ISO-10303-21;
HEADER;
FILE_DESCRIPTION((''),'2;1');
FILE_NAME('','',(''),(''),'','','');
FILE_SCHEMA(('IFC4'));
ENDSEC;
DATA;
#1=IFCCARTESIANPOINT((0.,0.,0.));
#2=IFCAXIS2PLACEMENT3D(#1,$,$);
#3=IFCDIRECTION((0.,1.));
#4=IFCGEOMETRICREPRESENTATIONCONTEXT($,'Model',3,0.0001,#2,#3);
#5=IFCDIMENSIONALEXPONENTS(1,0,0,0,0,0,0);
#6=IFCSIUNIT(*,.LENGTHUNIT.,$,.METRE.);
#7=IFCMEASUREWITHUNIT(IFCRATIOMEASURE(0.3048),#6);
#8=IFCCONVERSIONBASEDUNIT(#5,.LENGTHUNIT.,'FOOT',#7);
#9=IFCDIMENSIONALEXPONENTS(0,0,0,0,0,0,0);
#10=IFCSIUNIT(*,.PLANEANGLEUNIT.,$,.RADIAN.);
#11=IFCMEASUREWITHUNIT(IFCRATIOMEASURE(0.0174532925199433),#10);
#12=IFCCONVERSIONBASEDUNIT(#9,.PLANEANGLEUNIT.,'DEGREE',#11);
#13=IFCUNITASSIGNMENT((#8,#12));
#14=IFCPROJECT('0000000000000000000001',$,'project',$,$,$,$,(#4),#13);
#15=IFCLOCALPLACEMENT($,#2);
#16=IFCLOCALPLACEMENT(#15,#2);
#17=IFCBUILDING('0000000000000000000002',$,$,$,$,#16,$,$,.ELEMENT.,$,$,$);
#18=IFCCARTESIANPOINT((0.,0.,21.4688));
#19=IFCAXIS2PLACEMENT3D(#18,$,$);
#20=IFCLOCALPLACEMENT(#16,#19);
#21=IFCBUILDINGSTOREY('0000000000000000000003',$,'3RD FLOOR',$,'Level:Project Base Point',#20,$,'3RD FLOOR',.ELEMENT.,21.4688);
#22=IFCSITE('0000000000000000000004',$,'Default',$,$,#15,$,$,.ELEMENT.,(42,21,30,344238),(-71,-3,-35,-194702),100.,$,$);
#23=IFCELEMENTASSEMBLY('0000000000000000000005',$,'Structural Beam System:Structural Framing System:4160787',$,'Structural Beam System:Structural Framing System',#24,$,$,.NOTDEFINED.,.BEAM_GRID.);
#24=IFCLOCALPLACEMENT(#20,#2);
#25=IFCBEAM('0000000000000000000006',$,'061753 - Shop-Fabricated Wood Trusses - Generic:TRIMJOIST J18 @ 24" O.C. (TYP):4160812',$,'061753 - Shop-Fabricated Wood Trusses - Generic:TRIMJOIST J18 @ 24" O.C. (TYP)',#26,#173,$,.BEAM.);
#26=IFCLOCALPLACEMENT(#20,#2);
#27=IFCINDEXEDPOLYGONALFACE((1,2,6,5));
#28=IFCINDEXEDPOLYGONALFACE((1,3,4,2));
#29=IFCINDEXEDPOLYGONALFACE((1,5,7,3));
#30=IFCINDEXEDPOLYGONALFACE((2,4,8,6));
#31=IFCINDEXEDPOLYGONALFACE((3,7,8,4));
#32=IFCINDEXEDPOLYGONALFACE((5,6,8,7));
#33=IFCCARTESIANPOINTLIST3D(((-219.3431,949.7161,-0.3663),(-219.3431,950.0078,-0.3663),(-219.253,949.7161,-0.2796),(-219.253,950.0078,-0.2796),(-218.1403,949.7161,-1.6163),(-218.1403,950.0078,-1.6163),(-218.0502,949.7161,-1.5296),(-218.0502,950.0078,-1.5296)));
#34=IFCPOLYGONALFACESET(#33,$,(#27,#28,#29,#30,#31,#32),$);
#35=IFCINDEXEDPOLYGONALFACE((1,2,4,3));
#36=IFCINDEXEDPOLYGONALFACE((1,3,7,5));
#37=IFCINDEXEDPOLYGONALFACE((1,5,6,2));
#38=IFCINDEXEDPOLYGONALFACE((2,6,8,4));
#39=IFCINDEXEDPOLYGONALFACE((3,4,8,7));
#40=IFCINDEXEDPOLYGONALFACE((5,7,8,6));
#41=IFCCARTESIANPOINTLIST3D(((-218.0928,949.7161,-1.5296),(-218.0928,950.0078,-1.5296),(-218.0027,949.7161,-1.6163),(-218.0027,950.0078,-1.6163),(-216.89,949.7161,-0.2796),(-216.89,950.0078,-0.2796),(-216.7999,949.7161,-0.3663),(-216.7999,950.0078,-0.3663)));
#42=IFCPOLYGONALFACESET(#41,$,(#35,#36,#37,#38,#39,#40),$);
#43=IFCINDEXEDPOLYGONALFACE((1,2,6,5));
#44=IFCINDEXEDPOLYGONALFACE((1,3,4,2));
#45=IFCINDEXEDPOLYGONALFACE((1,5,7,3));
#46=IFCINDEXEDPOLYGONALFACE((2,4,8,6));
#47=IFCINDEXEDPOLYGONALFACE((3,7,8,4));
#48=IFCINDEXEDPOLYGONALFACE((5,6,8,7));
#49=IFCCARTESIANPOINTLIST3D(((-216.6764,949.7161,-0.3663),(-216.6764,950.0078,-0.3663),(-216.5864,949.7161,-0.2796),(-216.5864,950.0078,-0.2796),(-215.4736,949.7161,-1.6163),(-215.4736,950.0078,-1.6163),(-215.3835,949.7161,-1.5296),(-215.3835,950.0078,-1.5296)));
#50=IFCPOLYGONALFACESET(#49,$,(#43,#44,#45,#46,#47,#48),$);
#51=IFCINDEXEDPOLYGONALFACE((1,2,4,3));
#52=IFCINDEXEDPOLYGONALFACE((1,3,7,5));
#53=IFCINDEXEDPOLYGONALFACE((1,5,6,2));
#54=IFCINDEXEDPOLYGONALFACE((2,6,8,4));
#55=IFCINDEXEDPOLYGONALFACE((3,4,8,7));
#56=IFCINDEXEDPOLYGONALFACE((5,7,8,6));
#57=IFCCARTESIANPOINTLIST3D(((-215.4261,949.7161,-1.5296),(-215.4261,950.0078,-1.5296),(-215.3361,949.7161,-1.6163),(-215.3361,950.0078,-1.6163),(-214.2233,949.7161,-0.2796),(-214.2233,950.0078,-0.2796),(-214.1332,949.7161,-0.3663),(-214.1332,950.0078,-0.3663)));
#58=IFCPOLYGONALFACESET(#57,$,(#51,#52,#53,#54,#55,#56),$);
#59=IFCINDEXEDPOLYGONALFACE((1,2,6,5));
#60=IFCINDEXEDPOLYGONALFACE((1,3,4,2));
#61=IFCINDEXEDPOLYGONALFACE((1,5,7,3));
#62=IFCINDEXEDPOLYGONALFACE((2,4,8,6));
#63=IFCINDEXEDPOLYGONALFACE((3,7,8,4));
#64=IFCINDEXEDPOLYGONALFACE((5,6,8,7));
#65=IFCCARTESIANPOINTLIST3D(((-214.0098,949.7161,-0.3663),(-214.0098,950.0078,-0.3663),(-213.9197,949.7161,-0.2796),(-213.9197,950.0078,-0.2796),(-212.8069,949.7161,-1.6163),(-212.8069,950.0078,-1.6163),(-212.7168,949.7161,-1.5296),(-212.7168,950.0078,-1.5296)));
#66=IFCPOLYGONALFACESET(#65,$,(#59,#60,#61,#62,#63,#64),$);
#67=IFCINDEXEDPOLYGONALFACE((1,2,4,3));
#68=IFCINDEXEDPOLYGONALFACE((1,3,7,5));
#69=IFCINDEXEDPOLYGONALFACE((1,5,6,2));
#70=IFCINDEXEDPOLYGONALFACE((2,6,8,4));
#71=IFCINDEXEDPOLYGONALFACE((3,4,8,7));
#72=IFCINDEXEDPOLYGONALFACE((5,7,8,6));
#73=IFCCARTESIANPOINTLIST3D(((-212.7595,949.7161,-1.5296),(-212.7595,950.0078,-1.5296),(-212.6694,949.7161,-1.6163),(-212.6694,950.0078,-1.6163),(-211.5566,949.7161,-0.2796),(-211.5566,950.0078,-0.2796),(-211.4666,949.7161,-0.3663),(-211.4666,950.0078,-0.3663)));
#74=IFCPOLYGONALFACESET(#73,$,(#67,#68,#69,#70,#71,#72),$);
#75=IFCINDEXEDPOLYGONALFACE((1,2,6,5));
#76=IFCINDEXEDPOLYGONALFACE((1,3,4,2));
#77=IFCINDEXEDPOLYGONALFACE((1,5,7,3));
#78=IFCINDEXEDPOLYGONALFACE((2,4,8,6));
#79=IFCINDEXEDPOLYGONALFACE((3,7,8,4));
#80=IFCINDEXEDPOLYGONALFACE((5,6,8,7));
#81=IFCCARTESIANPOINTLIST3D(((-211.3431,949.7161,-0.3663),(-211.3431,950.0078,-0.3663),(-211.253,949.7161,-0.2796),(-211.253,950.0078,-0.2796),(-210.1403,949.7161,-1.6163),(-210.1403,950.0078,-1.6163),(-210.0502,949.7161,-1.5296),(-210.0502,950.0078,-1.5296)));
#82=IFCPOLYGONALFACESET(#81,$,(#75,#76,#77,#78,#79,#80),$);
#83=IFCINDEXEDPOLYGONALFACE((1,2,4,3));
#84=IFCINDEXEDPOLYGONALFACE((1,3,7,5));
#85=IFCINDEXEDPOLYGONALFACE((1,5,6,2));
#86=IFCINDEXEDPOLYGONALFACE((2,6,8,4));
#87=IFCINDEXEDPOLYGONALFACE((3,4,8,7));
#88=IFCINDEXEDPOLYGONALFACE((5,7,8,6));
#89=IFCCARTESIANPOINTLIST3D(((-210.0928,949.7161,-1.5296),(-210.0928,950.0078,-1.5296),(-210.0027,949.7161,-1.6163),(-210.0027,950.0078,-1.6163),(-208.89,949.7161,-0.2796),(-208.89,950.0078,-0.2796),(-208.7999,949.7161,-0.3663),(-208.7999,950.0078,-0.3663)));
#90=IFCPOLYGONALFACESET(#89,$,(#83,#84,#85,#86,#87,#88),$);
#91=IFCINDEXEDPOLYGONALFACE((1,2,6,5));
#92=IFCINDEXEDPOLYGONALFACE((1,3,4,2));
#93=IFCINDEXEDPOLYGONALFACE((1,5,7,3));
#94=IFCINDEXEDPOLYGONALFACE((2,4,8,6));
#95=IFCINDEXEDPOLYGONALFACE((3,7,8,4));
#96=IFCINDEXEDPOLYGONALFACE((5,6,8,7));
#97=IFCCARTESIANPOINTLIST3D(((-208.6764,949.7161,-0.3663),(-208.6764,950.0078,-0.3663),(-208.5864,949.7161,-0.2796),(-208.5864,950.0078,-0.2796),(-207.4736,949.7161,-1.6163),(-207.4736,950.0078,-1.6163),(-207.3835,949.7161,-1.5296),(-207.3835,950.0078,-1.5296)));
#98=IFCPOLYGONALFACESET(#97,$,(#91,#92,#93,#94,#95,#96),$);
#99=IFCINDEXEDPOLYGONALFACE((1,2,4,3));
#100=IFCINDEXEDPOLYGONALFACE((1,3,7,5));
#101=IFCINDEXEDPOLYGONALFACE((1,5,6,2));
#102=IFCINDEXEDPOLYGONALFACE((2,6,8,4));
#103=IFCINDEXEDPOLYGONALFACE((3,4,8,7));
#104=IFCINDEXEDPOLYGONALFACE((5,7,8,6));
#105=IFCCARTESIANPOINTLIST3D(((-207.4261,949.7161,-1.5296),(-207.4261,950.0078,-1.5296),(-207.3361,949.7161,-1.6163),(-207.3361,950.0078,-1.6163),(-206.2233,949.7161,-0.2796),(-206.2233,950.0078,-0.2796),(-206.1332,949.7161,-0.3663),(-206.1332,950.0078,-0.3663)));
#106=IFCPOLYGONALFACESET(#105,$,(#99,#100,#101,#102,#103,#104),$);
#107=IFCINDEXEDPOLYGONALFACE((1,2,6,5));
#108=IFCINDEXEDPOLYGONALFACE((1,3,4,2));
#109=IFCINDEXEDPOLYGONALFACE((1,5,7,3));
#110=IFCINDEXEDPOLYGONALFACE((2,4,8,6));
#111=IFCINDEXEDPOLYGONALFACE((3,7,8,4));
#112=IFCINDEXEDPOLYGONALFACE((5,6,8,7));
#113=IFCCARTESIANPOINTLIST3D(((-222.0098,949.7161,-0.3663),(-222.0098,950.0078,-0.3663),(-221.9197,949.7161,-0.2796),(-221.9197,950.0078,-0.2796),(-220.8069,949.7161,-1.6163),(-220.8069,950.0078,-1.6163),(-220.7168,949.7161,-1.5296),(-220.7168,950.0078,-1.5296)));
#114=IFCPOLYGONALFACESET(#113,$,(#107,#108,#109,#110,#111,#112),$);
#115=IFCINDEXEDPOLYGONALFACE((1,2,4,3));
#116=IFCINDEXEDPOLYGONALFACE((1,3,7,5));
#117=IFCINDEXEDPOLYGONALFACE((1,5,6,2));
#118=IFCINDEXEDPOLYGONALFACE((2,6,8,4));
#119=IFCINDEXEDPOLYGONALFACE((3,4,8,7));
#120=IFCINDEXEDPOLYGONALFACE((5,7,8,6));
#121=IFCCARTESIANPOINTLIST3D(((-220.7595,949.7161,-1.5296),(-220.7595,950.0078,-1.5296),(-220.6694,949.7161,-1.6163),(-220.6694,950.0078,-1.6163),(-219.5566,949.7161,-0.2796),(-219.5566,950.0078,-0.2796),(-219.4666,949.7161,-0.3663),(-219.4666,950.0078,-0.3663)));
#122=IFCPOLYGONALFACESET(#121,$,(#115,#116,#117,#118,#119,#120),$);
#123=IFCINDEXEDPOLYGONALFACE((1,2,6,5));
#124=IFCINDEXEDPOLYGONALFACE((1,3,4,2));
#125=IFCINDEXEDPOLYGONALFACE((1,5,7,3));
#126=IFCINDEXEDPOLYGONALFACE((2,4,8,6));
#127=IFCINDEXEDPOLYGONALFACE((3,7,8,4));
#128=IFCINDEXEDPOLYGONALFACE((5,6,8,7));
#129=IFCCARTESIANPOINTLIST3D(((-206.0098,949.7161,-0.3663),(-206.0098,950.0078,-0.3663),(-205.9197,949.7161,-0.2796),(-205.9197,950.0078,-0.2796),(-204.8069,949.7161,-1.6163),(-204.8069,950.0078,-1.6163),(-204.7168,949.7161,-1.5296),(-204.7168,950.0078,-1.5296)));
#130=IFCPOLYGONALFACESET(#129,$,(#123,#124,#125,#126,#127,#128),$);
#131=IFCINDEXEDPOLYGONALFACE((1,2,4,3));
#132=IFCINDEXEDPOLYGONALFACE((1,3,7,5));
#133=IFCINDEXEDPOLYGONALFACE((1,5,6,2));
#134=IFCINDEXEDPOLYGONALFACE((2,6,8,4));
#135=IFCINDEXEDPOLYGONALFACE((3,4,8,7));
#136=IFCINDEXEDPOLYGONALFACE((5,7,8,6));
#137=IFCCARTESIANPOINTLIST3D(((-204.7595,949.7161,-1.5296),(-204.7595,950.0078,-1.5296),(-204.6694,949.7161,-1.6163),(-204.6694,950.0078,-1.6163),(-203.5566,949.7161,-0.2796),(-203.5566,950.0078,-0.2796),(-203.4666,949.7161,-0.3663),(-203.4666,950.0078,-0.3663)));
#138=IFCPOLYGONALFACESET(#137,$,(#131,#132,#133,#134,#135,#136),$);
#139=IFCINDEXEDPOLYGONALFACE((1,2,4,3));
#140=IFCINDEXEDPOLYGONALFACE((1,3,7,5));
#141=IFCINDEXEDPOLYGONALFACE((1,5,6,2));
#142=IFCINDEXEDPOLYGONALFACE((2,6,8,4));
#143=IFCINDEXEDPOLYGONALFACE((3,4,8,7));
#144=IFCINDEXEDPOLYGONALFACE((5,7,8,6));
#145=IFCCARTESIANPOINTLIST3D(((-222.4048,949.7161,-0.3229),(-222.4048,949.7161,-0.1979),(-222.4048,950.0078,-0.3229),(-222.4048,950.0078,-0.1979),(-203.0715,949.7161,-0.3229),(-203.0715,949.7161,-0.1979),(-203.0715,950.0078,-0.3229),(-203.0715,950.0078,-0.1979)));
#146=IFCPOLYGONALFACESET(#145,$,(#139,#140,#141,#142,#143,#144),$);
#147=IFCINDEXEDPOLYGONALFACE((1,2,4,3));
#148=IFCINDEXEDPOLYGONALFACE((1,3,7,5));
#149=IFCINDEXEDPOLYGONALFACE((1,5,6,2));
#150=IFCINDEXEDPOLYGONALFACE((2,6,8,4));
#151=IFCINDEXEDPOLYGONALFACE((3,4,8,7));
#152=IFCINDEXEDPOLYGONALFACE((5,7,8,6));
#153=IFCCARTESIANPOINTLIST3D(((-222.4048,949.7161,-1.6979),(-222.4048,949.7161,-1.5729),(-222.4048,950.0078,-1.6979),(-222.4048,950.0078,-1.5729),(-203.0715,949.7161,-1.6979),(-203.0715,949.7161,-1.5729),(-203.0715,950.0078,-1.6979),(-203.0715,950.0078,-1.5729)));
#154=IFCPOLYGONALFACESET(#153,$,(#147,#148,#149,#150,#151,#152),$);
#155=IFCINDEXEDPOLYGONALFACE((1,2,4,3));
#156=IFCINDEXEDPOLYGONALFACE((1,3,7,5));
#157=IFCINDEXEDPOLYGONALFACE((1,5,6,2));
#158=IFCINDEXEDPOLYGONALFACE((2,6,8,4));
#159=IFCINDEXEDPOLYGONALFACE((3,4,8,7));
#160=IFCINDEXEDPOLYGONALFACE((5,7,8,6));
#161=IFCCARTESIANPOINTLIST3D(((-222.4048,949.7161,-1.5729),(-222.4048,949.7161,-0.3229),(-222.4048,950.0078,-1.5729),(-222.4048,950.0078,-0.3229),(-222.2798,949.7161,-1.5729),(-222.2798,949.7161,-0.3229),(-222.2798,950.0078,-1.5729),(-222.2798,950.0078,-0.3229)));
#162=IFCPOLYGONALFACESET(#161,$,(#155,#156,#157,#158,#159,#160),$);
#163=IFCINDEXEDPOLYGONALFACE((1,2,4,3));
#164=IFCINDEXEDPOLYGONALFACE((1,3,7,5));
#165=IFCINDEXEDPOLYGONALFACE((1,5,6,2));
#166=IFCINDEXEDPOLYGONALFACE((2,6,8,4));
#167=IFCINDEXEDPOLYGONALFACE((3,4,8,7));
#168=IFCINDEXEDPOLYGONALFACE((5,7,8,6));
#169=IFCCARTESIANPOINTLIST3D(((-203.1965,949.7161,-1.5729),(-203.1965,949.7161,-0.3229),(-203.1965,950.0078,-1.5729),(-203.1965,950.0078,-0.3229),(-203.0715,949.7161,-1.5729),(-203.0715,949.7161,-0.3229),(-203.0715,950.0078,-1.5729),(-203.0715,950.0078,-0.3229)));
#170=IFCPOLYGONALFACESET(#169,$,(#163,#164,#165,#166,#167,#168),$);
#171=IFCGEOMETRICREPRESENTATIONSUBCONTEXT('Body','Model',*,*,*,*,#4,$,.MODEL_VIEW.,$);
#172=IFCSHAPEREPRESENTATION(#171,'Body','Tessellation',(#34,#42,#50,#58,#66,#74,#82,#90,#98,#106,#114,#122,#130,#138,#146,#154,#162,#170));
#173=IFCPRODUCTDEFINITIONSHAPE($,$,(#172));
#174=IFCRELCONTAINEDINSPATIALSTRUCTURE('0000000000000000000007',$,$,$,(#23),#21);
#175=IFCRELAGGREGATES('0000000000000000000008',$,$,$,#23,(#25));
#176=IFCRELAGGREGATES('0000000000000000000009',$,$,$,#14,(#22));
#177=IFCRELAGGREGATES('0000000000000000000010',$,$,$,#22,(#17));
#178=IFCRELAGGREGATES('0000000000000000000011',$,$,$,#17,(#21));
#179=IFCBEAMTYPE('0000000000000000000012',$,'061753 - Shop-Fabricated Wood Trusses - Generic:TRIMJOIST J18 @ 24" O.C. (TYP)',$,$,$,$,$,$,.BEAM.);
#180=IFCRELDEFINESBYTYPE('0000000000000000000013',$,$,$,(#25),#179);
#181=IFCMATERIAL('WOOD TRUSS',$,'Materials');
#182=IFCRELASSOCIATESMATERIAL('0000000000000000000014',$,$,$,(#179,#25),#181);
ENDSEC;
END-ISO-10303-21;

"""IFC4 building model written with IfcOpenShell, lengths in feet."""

from ifc_helpers import new_model, entity, si_unit, converted_unit, direction, frame, frame_2d, origin, origin_2d_with_axis, place, context, subcontext, project, spatial, rectangle, extrude, source, transform, mapped, material, material_profile, profile_set, profile_usage, type_object, type_shapes, element, aggregate, save


model = new_model("IFC4")

# Units and contexts
model_context = context("Model", 3, precision=0.0001, world=origin(), true_north=direction((0.0, 1.0)))
body_context = subcontext(model_context, "Body", "Model", "MODEL_VIEW")
ifc_project = project(units=[converted_unit("LENGTHUNIT", "FOOT", entity("IfcRatioMeasure", 0.3048), si_unit("LENGTHUNIT", "METRE"), dimensions=[1, 0, 0, 0, 0, 0, 0]), converted_unit("PLANEANGLEUNIT", "DEGREE", entity("IfcRatioMeasure", 0.0174532925199433), si_unit("PLANEANGLEUNIT", "RADIAN"), dimensions=[0, 0, 0, 0, 0, 0, 0])], contexts=[model_context])

# Site, building, storey
site_placement = place(None, origin())
site = spatial("IfcSite", under=ifc_project, at=site_placement, Name="Default", CompositionType="ELEMENT", RefLatitude=(42, 21, 30, 344238), RefLongitude=(-71, -3, -35, -194702), RefElevation=100.0)
building_placement = place(site_placement, origin())
building = spatial("IfcBuilding", under=site, at=building_placement, CompositionType="ELEMENT")
storey_placement = place(building_placement, frame((0.0, 0.0, 21.4688)))
storey = spatial("IfcBuildingStorey", under=building, at=storey_placement, Name="3RD FLOOR", ObjectType="Level:Project Base Point", LongName="3RD FLOOR", CompositionType="ELEMENT", Elevation=21.4688)

# Shared definitions
ifc_material = material(Name="WOOD TRUSS", Category="Materials")
ifc_material_profile_1 = material_profile(ifc_material, rectangle(XDim=1.7347, YDim=0.125, at=frame_2d((0.0, 0.0), x_axis=(1.0, 0.0))), Name="TRIMJOIST J18 @ 24\" O.C. (TYP)")
ifc_material_profile_2 = material_profile(ifc_material, rectangle(XDim=1.7347, YDim=0.125, at=frame_2d((0.0, 0.0), x_axis=(1.0, 0.0))), Name="TRIMJOIST J18 @ 24\" O.C. (TYP)")
ifc_material_profile_3 = material_profile(ifc_material, rectangle(XDim=1.7347, YDim=0.125, at=frame_2d((0.0, 0.0), x_axis=(1.0, 0.0))), Name="TRIMJOIST J18 @ 24\" O.C. (TYP)")
ifc_material_profile_4 = material_profile(ifc_material, rectangle(XDim=1.7347, YDim=0.125, at=frame_2d((0.0, 0.0), x_axis=(1.0, 0.0))), Name="TRIMJOIST J18 @ 24\" O.C. (TYP)")
ifc_material_profile_5 = material_profile(ifc_material, rectangle(XDim=1.7347, YDim=0.125, at=frame_2d((0.0, 0.0), x_axis=(1.0, 0.0))), Name="TRIMJOIST J18 @ 24\" O.C. (TYP)")
ifc_material_profile_6 = material_profile(ifc_material, rectangle(XDim=1.7347, YDim=0.125, at=frame_2d((0.0, 0.0), x_axis=(1.0, 0.0))), Name="TRIMJOIST J18 @ 24\" O.C. (TYP)")
ifc_material_profile_7 = material_profile(ifc_material, rectangle(XDim=1.7347, YDim=0.125, at=frame_2d((0.0, 0.0), x_axis=(1.0, 0.0))), Name="TRIMJOIST J18 @ 24\" O.C. (TYP)")
ifc_material_profile_8 = material_profile(ifc_material, rectangle(XDim=1.7347, YDim=0.125, at=frame_2d((0.0, 0.0), x_axis=(1.0, 0.0))), Name="TRIMJOIST J18 @ 24\" O.C. (TYP)")
ifc_material_profile_9 = material_profile(ifc_material, rectangle(XDim=1.7347, YDim=0.125, at=frame_2d((0.0, 0.0), x_axis=(1.0, 0.0))), Name="TRIMJOIST J18 @ 24\" O.C. (TYP)")
ifc_material_profile_10 = material_profile(ifc_material, rectangle(XDim=1.7347, YDim=0.125, at=origin_2d_with_axis()), Name="TRIMJOIST J18 @ 24\" O.C. (TYP)")
ifc_material_profile_11 = material_profile(ifc_material, rectangle(XDim=0.125, YDim=0.2917, at=origin_2d_with_axis()), Name="TRIMJOIST J18 @ 24\" O.C. (TYP)")
ifc_material_profile_12 = material_profile(ifc_material, rectangle(XDim=0.125, YDim=0.2917, at=origin_2d_with_axis()), Name="TRIMJOIST J18 @ 24\" O.C. (TYP)")
ifc_material_profile_13 = material_profile(ifc_material, rectangle(XDim=1.25, YDim=0.2917, at=origin_2d_with_axis()), Name="TRIMJOIST J18 @ 24\" O.C. (TYP)")
ifc_material_profile_14 = material_profile(ifc_material, rectangle(XDim=1.25, YDim=0.2917, at=origin_2d_with_axis()), Name="TRIMJOIST J18 @ 24\" O.C. (TYP)")
ifc_profile_set = profile_set([ifc_material_profile_1, ifc_material_profile_2, ifc_material_profile_3, ifc_material_profile_4, ifc_material_profile_5, ifc_material_profile_6, ifc_material_profile_7, ifc_material_profile_8, ifc_material_profile_9, ifc_material_profile_10, ifc_material_profile_11, ifc_material_profile_12, ifc_material_profile_13, ifc_material_profile_14], Name="TRIMJOIST J18 @ 24\" O.C. (TYP)")
beam_type_1 = type_object("IfcBeamType", Name="061753 - Shop-Fabricated Wood Trusses - Generic:TRIMJOIST J18 @ 24\" O.C. (TYP)", PredefinedType="BEAM", material=ifc_profile_set)
shared_shape_1 = source(origin(), body_context, "Body", "SweptSolid", [
    extrude(rectangle(XDim=1.7347, YDim=0.125, at=frame_2d((0.0, 0.0), x_axis=(1.0, 0.0))), frame((5.9585, -0.1458, 0.0), z_axis=(0.0, 1.0, 0.0), x_axis=(0.693383, 0.0, 0.720569)), (0.0, 0.0, 1.0), 0.2917),
    extrude(rectangle(XDim=1.7347, YDim=0.125, at=origin_2d_with_axis()), frame((4.7082, -0.1458, 0.0), z_axis=(0.0, 1.0, 0.0), x_axis=(0.693383, 0.0, -0.720569)), (0.0, 0.0, 1.0), 0.2917),
    extrude(rectangle(XDim=1.7347, YDim=0.125, at=frame_2d((0.0, 0.0), x_axis=(1.0, 0.0))), frame((3.2918, -0.1458, 0.0), z_axis=(0.0, 1.0, 0.0), x_axis=(0.693383, 0.0, 0.720569)), (0.0, 0.0, 1.0), 0.2917),
    extrude(rectangle(XDim=1.7347, YDim=0.125, at=frame_2d((0.0, 0.0), x_axis=(1.0, 0.0))), frame((2.0415, -0.1458, 0.0), z_axis=(0.0, 1.0, 0.0), x_axis=(0.693383, 0.0, -0.720569)), (0.0, 0.0, 1.0), 0.2917),
    extrude(rectangle(XDim=1.7347, YDim=0.125, at=frame_2d((0.0, 0.0), x_axis=(1.0, 0.0))), frame((0.6251, -0.1458, 0.0), z_axis=(0.0, 1.0, 0.0), x_axis=(0.693383, 0.0, 0.720569)), (0.0, 0.0, 1.0), 0.2917),
    extrude(rectangle(XDim=1.7347, YDim=0.125, at=frame_2d((0.0, 0.0), x_axis=(1.0, 0.0))), frame((-0.6251, -0.1458, 0.0), z_axis=(0.0, 1.0, 0.0), x_axis=(0.693383, 0.0, -0.720569)), (0.0, 0.0, 1.0), 0.2917),
    extrude(rectangle(XDim=1.7347, YDim=0.125, at=frame_2d((0.0, 0.0), x_axis=(1.0, 0.0))), frame((-2.0415, -0.1458, 0.0), z_axis=(0.0, 1.0, 0.0), x_axis=(0.693383, 0.0, 0.720569)), (0.0, 0.0, 1.0), 0.2917),
    extrude(rectangle(XDim=1.7347, YDim=0.125, at=origin_2d_with_axis()), frame((-3.2918, -0.1458, 0.0), z_axis=(0.0, 1.0, 0.0), x_axis=(0.693383, 0.0, -0.720569)), (0.0, 0.0, 1.0), 0.2917),
    extrude(rectangle(XDim=1.7347, YDim=0.125, at=frame_2d((0.0, 0.0), x_axis=(1.0, 0.0))), frame((-4.7082, -0.1458, 0.0), z_axis=(0.0, 1.0, 0.0), x_axis=(0.693383, 0.0, 0.720569)), (0.0, 0.0, 1.0), 0.2917),
    extrude(rectangle(XDim=1.7347, YDim=0.125, at=frame_2d((0.0, 0.0), x_axis=(1.0, 0.0))), frame((-5.9585, -0.1458, 0.0), z_axis=(0.0, 1.0, 0.0), x_axis=(0.693383, 0.0, -0.720569)), (0.0, 0.0, 1.0), 0.2917),
    extrude(rectangle(XDim=1.7347, YDim=0.125, at=frame_2d((0.0, 0.0), x_axis=(1.0, 0.0))), frame((8.6251, -0.1458, 0.0), z_axis=(0.0, 1.0, 0.0), x_axis=(0.693383, 0.0, 0.720569)), (0.0, 0.0, 1.0), 0.2917),
    extrude(rectangle(XDim=1.7347, YDim=0.125, at=origin_2d_with_axis()), frame((7.3749, -0.1458, 0.0), z_axis=(0.0, 1.0, 0.0), x_axis=(0.693383, 0.0, -0.720569)), (0.0, 0.0, 1.0), 0.2917),
    extrude(rectangle(XDim=1.7347, YDim=0.125, at=frame_2d((0.0, 0.0), x_axis=(1.0, 0.0))), frame((-7.3749, -0.1458, 0.0), z_axis=(0.0, 1.0, 0.0), x_axis=(0.693383, 0.0, 0.720569)), (0.0, 0.0, 1.0), 0.2917),
    extrude(rectangle(XDim=1.7347, YDim=0.125, at=origin_2d_with_axis()), frame((-8.6251, -0.1458, 0.0), z_axis=(0.0, 1.0, 0.0), x_axis=(0.693383, 0.0, -0.720569)), (0.0, 0.0, 1.0), 0.2917),
    extrude(rectangle(XDim=0.125, YDim=0.2917, at=origin_2d_with_axis()), frame((-9.6667, 0.0, 0.6875), z_axis=(1.0, 0.0, 0.0), x_axis=(0.0, 0.0, -1.0)), (0.0, 0.0, 1.0), 19.3333),
    extrude(rectangle(XDim=0.125, YDim=0.2917, at=origin_2d_with_axis()), frame((-9.6667, 0.0, -0.6875), z_axis=(1.0, 0.0, 0.0), x_axis=(0.0, 0.0, -1.0)), (0.0, 0.0, 1.0), 19.3333),
    extrude(rectangle(XDim=1.25, YDim=0.2917, at=origin_2d_with_axis()), frame((9.5417, 0.0, 0.0), z_axis=(1.0, 0.0, 0.0), x_axis=(0.0, 0.0, -1.0)), (0.0, 0.0, 1.0), 0.125),
    extrude(rectangle(XDim=1.25, YDim=0.2917, at=origin_2d_with_axis()), frame((-9.6667, 0.0, 0.0), z_axis=(1.0, 0.0, 0.0), x_axis=(0.0, 0.0, -1.0)), (0.0, 0.0, 1.0), 0.125),
])
type_shapes(beam_type_1, [shared_shape_1])

# Element assembly, beam
assembly_1_placement = place(storey_placement, origin())
assembly_1 = element("IfcElementAssembly", 1, at=assembly_1_placement, inside=storey, Name="Structural Beam System:Structural Framing System:4160787", ObjectType="Structural Beam System:Structural Framing System", AssemblyPlace="NOTDEFINED", PredefinedType="BEAM_GRID")
ifc_profile_usage_1 = profile_usage(ifc_profile_set, cardinal=8)
beam_1_placement = place(assembly_1_placement, frame((-212.7382, 949.8619, -0.9479), z_axis=(0.0, 0.0, 1.0), x_axis=(-1.0, 0.0, 0.0)))
beam_1 = element("IfcBeam", 2, at=beam_1_placement, type_object=beam_type_1, material=ifc_profile_usage_1, Name="061753 - Shop-Fabricated Wood Trusses - Generic:TRIMJOIST J18 @ 24\" O.C. (TYP):4160812", ObjectType="061753 - Shop-Fabricated Wood Trusses - Generic:TRIMJOIST J18 @ 24\" O.C. (TYP)", PredefinedType="BEAM", context=body_context, shape_type="MappedRepresentation", body=[
    mapped(shared_shape_1, transform((0.0, 0.0, 0.0), scale=1.0)),
])
aggregate(assembly_1, [beam_1])

save(model, "model.ifc")
